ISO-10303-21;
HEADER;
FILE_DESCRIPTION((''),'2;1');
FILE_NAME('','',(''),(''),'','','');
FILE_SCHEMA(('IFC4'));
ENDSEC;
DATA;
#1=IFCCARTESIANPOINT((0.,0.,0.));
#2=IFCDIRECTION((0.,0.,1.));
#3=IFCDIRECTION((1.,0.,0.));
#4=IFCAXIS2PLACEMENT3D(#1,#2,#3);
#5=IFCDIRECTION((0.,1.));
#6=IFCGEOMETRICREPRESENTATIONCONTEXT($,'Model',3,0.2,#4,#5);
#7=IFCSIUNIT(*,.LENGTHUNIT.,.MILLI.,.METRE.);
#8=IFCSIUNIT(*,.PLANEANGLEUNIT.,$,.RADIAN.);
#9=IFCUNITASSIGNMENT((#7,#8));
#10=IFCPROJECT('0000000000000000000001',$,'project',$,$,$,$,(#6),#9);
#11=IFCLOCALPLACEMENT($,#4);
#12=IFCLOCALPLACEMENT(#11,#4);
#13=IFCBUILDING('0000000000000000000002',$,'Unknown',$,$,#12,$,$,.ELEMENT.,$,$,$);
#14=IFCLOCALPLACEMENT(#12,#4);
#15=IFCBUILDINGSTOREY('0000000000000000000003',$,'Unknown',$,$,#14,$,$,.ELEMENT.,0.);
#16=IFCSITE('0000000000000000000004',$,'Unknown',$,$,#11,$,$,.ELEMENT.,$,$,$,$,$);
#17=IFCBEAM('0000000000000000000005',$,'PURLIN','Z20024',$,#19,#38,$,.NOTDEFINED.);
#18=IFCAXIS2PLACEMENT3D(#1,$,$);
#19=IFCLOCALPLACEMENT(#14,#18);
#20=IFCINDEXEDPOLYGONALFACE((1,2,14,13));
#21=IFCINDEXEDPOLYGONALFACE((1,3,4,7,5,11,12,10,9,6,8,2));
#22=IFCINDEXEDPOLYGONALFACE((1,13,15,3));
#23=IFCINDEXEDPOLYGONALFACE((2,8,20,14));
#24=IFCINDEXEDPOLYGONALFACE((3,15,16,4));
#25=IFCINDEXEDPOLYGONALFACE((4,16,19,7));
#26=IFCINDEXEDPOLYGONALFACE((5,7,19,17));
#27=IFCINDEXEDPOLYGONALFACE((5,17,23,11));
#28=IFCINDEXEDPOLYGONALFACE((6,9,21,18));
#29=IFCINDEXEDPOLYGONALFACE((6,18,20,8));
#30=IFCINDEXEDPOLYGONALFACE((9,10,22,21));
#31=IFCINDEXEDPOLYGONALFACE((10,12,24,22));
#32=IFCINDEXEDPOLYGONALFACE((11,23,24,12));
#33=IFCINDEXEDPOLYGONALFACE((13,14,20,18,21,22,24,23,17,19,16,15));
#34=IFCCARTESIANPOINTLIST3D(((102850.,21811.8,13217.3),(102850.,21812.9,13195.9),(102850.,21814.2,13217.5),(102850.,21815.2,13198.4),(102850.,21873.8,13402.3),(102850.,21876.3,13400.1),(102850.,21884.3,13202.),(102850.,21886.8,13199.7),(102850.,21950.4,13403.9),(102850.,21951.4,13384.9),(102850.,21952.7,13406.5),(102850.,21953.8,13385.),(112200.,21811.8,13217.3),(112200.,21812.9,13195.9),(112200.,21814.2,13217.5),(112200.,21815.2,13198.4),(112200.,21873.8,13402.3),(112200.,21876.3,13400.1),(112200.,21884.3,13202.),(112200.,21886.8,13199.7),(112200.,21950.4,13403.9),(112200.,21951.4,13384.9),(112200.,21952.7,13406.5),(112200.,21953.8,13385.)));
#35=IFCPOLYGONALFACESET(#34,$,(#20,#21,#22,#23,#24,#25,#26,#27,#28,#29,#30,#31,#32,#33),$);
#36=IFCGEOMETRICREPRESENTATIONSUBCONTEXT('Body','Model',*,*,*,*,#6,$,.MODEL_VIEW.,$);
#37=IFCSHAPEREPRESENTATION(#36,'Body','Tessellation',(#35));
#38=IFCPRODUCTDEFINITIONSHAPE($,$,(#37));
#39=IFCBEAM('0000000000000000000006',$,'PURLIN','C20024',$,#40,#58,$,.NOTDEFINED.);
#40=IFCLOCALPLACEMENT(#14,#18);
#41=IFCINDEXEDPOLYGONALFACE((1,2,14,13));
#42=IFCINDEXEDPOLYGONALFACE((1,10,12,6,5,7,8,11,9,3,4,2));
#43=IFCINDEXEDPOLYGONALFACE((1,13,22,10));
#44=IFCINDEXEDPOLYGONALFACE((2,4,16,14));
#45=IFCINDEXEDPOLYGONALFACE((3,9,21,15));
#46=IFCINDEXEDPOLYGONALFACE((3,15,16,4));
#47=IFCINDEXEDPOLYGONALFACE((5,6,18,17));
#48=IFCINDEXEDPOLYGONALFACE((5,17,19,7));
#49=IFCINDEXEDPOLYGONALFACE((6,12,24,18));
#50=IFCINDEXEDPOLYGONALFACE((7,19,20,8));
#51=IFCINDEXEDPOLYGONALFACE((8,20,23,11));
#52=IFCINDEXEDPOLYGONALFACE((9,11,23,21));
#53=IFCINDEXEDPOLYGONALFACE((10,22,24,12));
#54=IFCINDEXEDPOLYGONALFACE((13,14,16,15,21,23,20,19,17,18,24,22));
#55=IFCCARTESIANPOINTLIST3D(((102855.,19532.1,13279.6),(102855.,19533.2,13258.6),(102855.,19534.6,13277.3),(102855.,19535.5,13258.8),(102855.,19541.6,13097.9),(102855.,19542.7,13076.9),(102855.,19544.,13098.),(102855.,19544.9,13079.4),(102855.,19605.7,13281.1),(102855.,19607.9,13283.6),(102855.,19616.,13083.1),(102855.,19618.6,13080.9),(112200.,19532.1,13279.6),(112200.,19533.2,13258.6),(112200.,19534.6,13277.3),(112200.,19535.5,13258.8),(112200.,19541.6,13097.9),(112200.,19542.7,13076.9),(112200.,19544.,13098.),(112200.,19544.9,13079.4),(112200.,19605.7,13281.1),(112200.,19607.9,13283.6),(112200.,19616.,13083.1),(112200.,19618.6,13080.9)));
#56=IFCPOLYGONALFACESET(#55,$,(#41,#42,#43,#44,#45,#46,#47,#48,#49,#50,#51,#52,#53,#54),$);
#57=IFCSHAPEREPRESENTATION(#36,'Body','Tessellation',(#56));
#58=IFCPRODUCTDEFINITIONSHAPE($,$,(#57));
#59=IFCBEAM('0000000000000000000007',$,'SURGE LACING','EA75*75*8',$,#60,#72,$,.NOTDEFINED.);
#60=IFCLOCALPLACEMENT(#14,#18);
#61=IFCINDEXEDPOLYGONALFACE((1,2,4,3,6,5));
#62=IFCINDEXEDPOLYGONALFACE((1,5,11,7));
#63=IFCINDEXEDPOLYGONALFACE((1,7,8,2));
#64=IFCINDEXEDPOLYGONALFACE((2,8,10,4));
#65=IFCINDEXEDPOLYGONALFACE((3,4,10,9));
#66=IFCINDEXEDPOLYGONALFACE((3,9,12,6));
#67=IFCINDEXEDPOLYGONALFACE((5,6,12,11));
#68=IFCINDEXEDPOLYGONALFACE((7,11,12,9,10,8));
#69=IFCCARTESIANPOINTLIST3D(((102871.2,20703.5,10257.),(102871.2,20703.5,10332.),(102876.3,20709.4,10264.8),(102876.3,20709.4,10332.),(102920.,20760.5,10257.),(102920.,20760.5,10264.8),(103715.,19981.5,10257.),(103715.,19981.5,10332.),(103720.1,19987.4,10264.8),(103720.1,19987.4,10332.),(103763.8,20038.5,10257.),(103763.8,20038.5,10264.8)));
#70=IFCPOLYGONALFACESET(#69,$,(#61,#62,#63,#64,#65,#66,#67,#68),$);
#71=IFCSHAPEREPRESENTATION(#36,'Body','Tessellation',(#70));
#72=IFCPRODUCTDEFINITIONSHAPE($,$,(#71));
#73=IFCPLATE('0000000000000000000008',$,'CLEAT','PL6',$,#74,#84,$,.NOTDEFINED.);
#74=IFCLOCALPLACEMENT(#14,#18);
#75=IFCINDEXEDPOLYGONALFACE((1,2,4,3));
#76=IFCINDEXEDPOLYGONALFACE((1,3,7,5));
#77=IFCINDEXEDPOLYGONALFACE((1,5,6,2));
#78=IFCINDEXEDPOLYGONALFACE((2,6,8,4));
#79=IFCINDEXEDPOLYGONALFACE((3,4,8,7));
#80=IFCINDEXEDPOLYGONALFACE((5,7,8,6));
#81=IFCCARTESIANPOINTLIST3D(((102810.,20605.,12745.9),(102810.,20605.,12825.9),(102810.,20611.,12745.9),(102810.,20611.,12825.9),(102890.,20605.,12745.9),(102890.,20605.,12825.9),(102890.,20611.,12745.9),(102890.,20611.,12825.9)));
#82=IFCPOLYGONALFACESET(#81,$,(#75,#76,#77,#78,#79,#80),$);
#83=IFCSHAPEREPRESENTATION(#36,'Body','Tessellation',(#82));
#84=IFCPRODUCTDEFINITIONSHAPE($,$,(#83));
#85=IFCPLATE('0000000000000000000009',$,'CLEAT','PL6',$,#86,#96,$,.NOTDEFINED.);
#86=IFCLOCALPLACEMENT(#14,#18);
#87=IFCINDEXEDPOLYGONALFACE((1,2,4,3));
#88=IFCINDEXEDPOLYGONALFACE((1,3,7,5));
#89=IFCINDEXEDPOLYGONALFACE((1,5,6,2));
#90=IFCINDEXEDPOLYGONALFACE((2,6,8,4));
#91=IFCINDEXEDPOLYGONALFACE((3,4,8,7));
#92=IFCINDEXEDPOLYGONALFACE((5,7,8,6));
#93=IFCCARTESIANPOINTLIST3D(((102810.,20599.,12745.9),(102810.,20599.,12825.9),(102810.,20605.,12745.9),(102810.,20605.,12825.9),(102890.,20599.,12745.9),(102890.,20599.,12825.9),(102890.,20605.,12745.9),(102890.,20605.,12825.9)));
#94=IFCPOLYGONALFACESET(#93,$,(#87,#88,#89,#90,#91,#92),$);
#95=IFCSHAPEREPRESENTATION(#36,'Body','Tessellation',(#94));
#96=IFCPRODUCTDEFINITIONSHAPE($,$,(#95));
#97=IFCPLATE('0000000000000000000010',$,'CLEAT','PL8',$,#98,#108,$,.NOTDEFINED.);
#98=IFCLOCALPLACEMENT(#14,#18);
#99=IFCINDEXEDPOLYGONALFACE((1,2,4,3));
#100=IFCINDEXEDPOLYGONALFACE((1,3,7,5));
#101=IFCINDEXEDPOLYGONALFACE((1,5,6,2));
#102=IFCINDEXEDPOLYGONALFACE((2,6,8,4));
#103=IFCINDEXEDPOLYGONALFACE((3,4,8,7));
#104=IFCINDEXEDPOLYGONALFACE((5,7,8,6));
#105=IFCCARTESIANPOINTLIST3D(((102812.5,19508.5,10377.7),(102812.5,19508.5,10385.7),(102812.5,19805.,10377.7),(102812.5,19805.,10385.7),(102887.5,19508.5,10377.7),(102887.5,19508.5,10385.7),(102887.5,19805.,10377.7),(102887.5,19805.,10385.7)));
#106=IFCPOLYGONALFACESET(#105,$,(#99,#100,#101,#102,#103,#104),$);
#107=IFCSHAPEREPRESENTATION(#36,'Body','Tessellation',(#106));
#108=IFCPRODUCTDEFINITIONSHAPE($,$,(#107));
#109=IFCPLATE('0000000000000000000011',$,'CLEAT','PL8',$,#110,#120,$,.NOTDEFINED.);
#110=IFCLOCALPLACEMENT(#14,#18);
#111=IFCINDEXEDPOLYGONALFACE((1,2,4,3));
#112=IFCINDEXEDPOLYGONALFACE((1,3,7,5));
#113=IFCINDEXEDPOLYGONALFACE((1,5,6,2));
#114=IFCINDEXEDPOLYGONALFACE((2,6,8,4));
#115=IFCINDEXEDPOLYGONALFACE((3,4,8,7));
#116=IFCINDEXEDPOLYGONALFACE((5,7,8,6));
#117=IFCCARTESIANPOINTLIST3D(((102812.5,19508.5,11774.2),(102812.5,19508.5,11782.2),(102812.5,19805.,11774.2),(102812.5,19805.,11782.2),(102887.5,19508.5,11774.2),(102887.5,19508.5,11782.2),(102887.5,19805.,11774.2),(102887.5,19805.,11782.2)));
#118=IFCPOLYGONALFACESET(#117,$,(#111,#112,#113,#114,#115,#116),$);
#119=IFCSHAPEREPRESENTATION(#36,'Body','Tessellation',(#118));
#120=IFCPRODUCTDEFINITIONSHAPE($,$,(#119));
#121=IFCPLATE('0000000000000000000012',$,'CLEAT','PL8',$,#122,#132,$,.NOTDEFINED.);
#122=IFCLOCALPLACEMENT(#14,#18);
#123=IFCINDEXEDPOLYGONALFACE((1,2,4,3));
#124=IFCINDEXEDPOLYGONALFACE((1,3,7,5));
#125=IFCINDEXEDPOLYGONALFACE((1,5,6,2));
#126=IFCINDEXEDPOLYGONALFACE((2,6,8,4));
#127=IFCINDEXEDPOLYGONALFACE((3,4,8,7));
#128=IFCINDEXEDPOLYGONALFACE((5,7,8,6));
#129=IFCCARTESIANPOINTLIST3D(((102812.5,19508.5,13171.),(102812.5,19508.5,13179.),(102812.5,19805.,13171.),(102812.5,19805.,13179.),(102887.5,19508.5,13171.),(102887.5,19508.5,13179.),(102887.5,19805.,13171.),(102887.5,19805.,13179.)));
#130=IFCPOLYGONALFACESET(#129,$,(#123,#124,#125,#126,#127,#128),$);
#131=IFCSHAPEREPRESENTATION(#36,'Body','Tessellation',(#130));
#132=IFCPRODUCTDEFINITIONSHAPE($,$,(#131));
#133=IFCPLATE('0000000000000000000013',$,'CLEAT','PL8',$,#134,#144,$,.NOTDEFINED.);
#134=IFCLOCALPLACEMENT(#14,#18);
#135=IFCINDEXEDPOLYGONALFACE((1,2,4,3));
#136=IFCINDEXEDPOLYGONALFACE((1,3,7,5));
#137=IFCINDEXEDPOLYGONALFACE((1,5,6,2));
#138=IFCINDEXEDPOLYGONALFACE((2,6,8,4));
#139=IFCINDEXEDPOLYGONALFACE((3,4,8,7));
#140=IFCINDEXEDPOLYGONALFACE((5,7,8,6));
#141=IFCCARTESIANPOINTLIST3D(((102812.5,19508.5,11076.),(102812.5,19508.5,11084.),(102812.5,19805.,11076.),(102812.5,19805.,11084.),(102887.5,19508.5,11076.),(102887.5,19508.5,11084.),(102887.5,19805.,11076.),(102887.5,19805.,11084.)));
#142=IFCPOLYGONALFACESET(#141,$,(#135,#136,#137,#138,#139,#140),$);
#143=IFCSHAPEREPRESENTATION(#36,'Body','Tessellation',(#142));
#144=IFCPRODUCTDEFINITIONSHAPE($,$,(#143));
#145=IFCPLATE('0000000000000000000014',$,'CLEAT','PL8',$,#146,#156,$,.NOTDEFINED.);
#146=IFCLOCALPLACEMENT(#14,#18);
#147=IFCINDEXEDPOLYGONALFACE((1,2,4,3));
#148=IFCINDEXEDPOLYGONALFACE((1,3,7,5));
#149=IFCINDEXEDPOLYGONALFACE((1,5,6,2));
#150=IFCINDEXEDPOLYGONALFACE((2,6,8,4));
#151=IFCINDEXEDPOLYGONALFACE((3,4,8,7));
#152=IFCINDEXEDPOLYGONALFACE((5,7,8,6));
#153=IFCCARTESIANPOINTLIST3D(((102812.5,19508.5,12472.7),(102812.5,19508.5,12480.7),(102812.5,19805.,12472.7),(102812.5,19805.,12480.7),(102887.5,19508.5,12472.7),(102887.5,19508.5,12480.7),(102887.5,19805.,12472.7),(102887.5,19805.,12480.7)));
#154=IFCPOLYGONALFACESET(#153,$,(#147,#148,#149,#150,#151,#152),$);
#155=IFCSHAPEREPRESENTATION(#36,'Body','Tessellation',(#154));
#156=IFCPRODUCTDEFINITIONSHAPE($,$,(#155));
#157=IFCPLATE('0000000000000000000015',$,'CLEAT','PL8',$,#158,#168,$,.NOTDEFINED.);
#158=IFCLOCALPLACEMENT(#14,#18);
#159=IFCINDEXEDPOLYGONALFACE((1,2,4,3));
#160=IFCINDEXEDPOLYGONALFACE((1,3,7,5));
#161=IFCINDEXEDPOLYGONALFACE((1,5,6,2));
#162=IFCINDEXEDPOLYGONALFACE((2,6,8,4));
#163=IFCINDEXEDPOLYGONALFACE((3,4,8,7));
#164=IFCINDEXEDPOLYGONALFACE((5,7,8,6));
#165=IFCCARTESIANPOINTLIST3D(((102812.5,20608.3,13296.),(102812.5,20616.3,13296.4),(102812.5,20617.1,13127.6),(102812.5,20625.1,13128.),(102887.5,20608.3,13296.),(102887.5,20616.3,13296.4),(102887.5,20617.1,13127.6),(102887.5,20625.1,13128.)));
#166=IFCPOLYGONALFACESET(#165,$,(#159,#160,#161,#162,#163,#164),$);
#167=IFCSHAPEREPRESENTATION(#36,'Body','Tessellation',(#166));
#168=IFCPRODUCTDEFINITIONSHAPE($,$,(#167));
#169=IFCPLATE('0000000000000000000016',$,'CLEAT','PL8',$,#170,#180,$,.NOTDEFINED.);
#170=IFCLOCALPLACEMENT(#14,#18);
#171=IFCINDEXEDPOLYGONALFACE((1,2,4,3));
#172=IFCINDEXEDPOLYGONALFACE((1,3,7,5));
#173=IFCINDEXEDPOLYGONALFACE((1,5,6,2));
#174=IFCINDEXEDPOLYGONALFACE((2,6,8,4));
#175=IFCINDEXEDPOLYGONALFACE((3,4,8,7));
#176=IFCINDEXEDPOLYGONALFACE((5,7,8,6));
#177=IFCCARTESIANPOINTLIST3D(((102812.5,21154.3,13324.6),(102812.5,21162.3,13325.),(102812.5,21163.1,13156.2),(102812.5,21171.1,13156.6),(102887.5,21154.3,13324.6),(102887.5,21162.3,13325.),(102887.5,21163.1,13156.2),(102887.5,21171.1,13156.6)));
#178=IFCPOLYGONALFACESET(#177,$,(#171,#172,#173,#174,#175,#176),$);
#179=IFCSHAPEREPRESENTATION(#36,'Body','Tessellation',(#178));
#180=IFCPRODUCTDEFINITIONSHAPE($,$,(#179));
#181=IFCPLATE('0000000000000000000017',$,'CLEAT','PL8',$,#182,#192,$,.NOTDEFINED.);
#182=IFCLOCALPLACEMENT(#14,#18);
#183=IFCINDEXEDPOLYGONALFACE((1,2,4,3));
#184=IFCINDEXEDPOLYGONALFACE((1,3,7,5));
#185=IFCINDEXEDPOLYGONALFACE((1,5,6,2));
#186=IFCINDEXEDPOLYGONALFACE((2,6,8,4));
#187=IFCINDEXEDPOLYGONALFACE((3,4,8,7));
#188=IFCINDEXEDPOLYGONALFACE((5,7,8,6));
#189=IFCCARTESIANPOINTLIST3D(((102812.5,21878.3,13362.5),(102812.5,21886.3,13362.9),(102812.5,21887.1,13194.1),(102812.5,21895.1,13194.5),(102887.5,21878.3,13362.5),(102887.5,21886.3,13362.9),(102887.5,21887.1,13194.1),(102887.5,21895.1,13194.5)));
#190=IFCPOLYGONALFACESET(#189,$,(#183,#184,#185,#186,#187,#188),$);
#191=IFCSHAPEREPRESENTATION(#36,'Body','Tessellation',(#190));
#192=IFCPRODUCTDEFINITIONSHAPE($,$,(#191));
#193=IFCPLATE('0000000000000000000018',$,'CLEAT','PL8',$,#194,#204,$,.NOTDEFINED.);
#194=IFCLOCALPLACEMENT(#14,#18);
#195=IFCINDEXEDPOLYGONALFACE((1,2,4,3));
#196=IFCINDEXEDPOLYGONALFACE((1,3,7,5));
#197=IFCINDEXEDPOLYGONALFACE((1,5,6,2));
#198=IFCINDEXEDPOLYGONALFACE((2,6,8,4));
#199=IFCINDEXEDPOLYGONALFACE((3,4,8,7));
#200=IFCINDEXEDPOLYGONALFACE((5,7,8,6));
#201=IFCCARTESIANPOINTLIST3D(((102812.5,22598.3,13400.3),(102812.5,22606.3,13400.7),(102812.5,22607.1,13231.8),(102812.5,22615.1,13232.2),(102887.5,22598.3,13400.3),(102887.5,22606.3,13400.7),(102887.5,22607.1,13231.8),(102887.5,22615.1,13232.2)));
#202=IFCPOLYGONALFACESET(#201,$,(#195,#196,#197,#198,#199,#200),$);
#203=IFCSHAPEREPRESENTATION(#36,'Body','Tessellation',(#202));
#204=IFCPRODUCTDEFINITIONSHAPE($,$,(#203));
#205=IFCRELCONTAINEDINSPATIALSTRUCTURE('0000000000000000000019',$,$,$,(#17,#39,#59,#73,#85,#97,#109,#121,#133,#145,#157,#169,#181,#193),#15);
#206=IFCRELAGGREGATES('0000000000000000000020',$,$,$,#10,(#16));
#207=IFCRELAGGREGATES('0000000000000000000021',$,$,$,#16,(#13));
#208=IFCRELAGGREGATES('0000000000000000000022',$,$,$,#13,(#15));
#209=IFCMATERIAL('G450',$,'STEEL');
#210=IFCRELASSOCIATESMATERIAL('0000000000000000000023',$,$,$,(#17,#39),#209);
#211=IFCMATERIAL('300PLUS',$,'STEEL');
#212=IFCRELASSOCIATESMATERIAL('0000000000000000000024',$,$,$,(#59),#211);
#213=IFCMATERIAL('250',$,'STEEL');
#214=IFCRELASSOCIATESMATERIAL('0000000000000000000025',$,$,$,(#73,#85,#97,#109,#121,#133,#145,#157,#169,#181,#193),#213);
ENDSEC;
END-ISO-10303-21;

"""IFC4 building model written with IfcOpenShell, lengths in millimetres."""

from ifc_helpers import new_model, si_unit, direction, frame, origin_with_axes, place, context, subcontext, project, spatial, line, indexed_curve, outline, extrude, material, element, save


model = new_model("IFC4")

# Units and contexts
model_context = context("Model", 3, precision=0.2, world=origin_with_axes(), true_north=direction((0.0, 1.0)))
body_context = subcontext(model_context, "Body", "Model", "MODEL_VIEW")
ifc_project = project(units=[si_unit("LENGTHUNIT", "METRE", prefix="MILLI"), si_unit("PLANEANGLEUNIT", "RADIAN")], contexts=[model_context])

# Site, building, storey
site_placement = place(None, origin_with_axes())
site = spatial("IfcSite", under=ifc_project, at=site_placement, Name="Unknown", CompositionType="ELEMENT")
building_placement = place(site_placement, origin_with_axes())
building = spatial("IfcBuilding", under=site, at=building_placement, Name="Unknown", CompositionType="ELEMENT")
storey_placement = place(building_placement, origin_with_axes())
storey = spatial("IfcBuildingStorey", under=building, at=storey_placement, Name="Unknown", CompositionType="ELEMENT", Elevation=0.0)

# Beams
ifc_material_1 = material(Name="G450", Category="STEEL")
beam_1_placement = place(storey_placement, frame((102850.0, 21880.3, 13301.0), z_axis=(0.0, -0.99863, -0.052336), x_axis=(1.0, 0.0, 0.0)))
element("IfcBeam", 1, at=beam_1_placement, inside=storey, material=ifc_material_1, Name="PURLIN", Description="Z20024", PredefinedType="NOTDEFINED", context=body_context, shape_type="SolidModel", body=[
    extrude(outline(indexed_curve([(72.8, -101.5), (72.8, -80.0), (70.4, -80.0), (70.4, -99.1), (1.2, -99.1), (1.2, 101.5), (-77.8, 101.5), (-77.8, 80.0), (-75.4, 80.0), (-75.4, 99.1), (-1.2, 99.1), (-1.2, -101.5)], segments=[line(1, 2, 3, 4, 5, 6, 7, 8, 9, 10, 11, 12, 1)])), frame((0.0, 0.0, 0.0), z_axis=(-1.0, 0.0, 0.0), x_axis=(0.0, 0.0, 1.0)), (0.0, 0.0, -1.0), 9350.0),
])
beam_2_placement = place(storey_placement, frame((102855.0, 19575.3, 13180.2), z_axis=(0.0, -0.99863, -0.052336), x_axis=(1.0, 0.0, 0.0)))
element("IfcBeam", 2, at=beam_2_placement, inside=storey, material=ifc_material_1, Name="PURLIN", Description="C20024", PredefinedType="NOTDEFINED", context=body_context, shape_type="SolidModel", body=[
    extrude(outline(indexed_curve([(38.0, -101.5), (38.0, -80.5), (35.6, -80.5), (35.6, -99.1), (-35.6, -99.1), (-35.6, 99.1), (35.6, 99.1), (35.6, 80.5), (38.0, 80.5), (38.0, 101.5), (-38.0, 101.5), (-38.0, -101.5)], segments=[line(1, 2, 3, 4, 5, 6, 7, 8, 9, 10, 11, 12, 1)])), frame((0.0, 0.0, 0.0), z_axis=(-1.0, 0.0, 0.0), x_axis=(0.0, 0.0, 1.0)), (0.0, 0.0, -1.0), 9345.0),
])
ifc_material_2 = material(Name="300PLUS", Category="STEEL")
beam_3_placement = place(storey_placement, frame((102895.6, 20732.0, 10294.5), z_axis=(0.0, 0.0, 1.0), x_axis=(0.759816, -0.650139, 0.0)))
element("IfcBeam", 3, at=beam_3_placement, inside=storey, material=ifc_material_2, Name="SURGE LACING", Description="EA75*75*8", PredefinedType="NOTDEFINED", context=body_context, shape_type="SolidModel", body=[
    extrude(outline(indexed_curve([(-37.5, -37.5), (37.5, -37.5), (37.5, -29.7), (-29.7, -29.7), (-29.7, 37.5), (-37.5, 37.5)], segments=[line(1, 2, 3, 4, 5, 6, 1)])), frame((0.0, 0.0, 0.0), z_axis=(-1.0, 0.0, 0.0), x_axis=(0.0, 0.0, 1.0)), (0.0, 0.0, -1.0), 1110.5),
])

# Plates
ifc_material_3 = material(Name="250", Category="STEEL")
for number, where, z_axis, x_axis, name in (
    (4, (102890.0, 20608.0, 12745.9), (0.0, 1.0, 0.0), (-1.0, 0.0, 0.0), "CLEAT"),
    (5, (102810.0, 20602.0, 12745.9), (0.0, -1.0, 0.0), (1.0, 0.0, 0.0), "CLEAT"),
):
    element("IfcPlate", number, at=place(storey_placement, frame(where, z_axis=z_axis, x_axis=x_axis)), inside=storey, material=ifc_material_3, Name=name, Description="PL6", PredefinedType="NOTDEFINED", context=body_context, shape_type="SolidModel", body=[
        extrude(outline(indexed_curve([(0.0, 0.0), (80.0, 0.0), (80.0, 80.0), (0.0, 80.0)], segments=[line(1, 2, 3, 4, 1)])), frame((0.0, 0.0, 3.0), z_axis=(0.0, 0.0, 1.0), x_axis=(1.0, 0.0, 0.0)), (0.0, 0.0, -1.0), 6.0),
    ])
for number, where, z_axis, x_axis, name in (
    (6, (102812.5, 19508.5, 10381.7), (0.0, 0.0, 1.0), (1.0, 0.0, 0.0), "CLEAT"),
    (7, (102812.5, 19508.5, 11778.2), (0.0, 0.0, 1.0), (1.0, 0.0, 0.0), "CLEAT"),
    (8, (102812.5, 19508.5, 13175.0), (0.0, 0.0, 1.0), (1.0, 0.0, 0.0), "CLEAT"),
    (9, (102812.5, 19508.5, 11080.0), (0.0, 0.0, 1.0), (1.0, 0.0, 0.0), "CLEAT"),
    (10, (102812.5, 19508.5, 12476.7), (0.0, 0.0, 1.0), (1.0, 0.0, 0.0), "CLEAT"),
):
    element("IfcPlate", number, at=place(storey_placement, frame(where, z_axis=z_axis, x_axis=x_axis)), inside=storey, material=ifc_material_3, Name=name, Description="PL8", PredefinedType="NOTDEFINED", context=body_context, shape_type="SolidModel", body=[
        extrude(outline(indexed_curve([(0.0, 0.0), (75.0, 0.0), (75.0, 296.5), (0.0, 296.5)], segments=[line(1, 2, 3, 4, 1)])), frame((0.0, 0.0, 4.0), z_axis=(0.0, 0.0, 1.0), x_axis=(1.0, 0.0, 0.0)), (0.0, 0.0, -1.0), 8.0),
    ])
for number, where, z_axis, x_axis, name in (
    (11, (102812.5, 20612.3, 13296.2), (0.0, 0.998637, 0.052185), (1.0, 0.0, 0.0), "CLEAT"),
    (12, (102812.5, 21158.3, 13324.8), (0.0, 0.998637, 0.052185), (1.0, 0.0, 0.0), "CLEAT"),
    (13, (102812.5, 21882.3, 13362.7), (0.0, 0.998637, 0.052185), (1.0, 0.0, 0.0), "CLEAT"),
):
    element("IfcPlate", number, at=place(storey_placement, frame(where, z_axis=z_axis, x_axis=x_axis)), inside=storey, material=ifc_material_3, Name=name, Description="PL8", PredefinedType="NOTDEFINED", context=body_context, shape_type="SolidModel", body=[
        extrude(outline(indexed_curve([(0.0, 0.0), (75.0, 0.0), (75.0, 168.6), (0.0, 168.6)], segments=[line(1, 2, 3, 4, 1)])), frame((0.0, 0.0, 4.0), z_axis=(0.0, 0.0, 1.0), x_axis=(1.0, 0.0, 0.0)), (0.0, 0.0, -1.0), 8.0),
    ])
plate_1_placement = place(storey_placement, frame((102812.5, 22602.3, 13400.5), z_axis=(0.0, 0.998639, 0.052154), x_axis=(1.0, 0.0, 0.0)))
element("IfcPlate", 14, at=plate_1_placement, inside=storey, material=ifc_material_3, Name="CLEAT", Description="PL8", PredefinedType="NOTDEFINED", context=body_context, shape_type="SolidModel", body=[
    extrude(outline(indexed_curve([(0.0, 0.0), (75.0, 0.0), (75.0, 168.7), (0.0, 168.7)], segments=[line(1, 2, 3, 4, 1)])), frame((0.0, 0.0, 4.0), z_axis=(0.0, 0.0, 1.0), x_axis=(1.0, 0.0, 0.0)), (0.0, 0.0, -1.0), 8.0),
])

save(model, "model.ifc")
